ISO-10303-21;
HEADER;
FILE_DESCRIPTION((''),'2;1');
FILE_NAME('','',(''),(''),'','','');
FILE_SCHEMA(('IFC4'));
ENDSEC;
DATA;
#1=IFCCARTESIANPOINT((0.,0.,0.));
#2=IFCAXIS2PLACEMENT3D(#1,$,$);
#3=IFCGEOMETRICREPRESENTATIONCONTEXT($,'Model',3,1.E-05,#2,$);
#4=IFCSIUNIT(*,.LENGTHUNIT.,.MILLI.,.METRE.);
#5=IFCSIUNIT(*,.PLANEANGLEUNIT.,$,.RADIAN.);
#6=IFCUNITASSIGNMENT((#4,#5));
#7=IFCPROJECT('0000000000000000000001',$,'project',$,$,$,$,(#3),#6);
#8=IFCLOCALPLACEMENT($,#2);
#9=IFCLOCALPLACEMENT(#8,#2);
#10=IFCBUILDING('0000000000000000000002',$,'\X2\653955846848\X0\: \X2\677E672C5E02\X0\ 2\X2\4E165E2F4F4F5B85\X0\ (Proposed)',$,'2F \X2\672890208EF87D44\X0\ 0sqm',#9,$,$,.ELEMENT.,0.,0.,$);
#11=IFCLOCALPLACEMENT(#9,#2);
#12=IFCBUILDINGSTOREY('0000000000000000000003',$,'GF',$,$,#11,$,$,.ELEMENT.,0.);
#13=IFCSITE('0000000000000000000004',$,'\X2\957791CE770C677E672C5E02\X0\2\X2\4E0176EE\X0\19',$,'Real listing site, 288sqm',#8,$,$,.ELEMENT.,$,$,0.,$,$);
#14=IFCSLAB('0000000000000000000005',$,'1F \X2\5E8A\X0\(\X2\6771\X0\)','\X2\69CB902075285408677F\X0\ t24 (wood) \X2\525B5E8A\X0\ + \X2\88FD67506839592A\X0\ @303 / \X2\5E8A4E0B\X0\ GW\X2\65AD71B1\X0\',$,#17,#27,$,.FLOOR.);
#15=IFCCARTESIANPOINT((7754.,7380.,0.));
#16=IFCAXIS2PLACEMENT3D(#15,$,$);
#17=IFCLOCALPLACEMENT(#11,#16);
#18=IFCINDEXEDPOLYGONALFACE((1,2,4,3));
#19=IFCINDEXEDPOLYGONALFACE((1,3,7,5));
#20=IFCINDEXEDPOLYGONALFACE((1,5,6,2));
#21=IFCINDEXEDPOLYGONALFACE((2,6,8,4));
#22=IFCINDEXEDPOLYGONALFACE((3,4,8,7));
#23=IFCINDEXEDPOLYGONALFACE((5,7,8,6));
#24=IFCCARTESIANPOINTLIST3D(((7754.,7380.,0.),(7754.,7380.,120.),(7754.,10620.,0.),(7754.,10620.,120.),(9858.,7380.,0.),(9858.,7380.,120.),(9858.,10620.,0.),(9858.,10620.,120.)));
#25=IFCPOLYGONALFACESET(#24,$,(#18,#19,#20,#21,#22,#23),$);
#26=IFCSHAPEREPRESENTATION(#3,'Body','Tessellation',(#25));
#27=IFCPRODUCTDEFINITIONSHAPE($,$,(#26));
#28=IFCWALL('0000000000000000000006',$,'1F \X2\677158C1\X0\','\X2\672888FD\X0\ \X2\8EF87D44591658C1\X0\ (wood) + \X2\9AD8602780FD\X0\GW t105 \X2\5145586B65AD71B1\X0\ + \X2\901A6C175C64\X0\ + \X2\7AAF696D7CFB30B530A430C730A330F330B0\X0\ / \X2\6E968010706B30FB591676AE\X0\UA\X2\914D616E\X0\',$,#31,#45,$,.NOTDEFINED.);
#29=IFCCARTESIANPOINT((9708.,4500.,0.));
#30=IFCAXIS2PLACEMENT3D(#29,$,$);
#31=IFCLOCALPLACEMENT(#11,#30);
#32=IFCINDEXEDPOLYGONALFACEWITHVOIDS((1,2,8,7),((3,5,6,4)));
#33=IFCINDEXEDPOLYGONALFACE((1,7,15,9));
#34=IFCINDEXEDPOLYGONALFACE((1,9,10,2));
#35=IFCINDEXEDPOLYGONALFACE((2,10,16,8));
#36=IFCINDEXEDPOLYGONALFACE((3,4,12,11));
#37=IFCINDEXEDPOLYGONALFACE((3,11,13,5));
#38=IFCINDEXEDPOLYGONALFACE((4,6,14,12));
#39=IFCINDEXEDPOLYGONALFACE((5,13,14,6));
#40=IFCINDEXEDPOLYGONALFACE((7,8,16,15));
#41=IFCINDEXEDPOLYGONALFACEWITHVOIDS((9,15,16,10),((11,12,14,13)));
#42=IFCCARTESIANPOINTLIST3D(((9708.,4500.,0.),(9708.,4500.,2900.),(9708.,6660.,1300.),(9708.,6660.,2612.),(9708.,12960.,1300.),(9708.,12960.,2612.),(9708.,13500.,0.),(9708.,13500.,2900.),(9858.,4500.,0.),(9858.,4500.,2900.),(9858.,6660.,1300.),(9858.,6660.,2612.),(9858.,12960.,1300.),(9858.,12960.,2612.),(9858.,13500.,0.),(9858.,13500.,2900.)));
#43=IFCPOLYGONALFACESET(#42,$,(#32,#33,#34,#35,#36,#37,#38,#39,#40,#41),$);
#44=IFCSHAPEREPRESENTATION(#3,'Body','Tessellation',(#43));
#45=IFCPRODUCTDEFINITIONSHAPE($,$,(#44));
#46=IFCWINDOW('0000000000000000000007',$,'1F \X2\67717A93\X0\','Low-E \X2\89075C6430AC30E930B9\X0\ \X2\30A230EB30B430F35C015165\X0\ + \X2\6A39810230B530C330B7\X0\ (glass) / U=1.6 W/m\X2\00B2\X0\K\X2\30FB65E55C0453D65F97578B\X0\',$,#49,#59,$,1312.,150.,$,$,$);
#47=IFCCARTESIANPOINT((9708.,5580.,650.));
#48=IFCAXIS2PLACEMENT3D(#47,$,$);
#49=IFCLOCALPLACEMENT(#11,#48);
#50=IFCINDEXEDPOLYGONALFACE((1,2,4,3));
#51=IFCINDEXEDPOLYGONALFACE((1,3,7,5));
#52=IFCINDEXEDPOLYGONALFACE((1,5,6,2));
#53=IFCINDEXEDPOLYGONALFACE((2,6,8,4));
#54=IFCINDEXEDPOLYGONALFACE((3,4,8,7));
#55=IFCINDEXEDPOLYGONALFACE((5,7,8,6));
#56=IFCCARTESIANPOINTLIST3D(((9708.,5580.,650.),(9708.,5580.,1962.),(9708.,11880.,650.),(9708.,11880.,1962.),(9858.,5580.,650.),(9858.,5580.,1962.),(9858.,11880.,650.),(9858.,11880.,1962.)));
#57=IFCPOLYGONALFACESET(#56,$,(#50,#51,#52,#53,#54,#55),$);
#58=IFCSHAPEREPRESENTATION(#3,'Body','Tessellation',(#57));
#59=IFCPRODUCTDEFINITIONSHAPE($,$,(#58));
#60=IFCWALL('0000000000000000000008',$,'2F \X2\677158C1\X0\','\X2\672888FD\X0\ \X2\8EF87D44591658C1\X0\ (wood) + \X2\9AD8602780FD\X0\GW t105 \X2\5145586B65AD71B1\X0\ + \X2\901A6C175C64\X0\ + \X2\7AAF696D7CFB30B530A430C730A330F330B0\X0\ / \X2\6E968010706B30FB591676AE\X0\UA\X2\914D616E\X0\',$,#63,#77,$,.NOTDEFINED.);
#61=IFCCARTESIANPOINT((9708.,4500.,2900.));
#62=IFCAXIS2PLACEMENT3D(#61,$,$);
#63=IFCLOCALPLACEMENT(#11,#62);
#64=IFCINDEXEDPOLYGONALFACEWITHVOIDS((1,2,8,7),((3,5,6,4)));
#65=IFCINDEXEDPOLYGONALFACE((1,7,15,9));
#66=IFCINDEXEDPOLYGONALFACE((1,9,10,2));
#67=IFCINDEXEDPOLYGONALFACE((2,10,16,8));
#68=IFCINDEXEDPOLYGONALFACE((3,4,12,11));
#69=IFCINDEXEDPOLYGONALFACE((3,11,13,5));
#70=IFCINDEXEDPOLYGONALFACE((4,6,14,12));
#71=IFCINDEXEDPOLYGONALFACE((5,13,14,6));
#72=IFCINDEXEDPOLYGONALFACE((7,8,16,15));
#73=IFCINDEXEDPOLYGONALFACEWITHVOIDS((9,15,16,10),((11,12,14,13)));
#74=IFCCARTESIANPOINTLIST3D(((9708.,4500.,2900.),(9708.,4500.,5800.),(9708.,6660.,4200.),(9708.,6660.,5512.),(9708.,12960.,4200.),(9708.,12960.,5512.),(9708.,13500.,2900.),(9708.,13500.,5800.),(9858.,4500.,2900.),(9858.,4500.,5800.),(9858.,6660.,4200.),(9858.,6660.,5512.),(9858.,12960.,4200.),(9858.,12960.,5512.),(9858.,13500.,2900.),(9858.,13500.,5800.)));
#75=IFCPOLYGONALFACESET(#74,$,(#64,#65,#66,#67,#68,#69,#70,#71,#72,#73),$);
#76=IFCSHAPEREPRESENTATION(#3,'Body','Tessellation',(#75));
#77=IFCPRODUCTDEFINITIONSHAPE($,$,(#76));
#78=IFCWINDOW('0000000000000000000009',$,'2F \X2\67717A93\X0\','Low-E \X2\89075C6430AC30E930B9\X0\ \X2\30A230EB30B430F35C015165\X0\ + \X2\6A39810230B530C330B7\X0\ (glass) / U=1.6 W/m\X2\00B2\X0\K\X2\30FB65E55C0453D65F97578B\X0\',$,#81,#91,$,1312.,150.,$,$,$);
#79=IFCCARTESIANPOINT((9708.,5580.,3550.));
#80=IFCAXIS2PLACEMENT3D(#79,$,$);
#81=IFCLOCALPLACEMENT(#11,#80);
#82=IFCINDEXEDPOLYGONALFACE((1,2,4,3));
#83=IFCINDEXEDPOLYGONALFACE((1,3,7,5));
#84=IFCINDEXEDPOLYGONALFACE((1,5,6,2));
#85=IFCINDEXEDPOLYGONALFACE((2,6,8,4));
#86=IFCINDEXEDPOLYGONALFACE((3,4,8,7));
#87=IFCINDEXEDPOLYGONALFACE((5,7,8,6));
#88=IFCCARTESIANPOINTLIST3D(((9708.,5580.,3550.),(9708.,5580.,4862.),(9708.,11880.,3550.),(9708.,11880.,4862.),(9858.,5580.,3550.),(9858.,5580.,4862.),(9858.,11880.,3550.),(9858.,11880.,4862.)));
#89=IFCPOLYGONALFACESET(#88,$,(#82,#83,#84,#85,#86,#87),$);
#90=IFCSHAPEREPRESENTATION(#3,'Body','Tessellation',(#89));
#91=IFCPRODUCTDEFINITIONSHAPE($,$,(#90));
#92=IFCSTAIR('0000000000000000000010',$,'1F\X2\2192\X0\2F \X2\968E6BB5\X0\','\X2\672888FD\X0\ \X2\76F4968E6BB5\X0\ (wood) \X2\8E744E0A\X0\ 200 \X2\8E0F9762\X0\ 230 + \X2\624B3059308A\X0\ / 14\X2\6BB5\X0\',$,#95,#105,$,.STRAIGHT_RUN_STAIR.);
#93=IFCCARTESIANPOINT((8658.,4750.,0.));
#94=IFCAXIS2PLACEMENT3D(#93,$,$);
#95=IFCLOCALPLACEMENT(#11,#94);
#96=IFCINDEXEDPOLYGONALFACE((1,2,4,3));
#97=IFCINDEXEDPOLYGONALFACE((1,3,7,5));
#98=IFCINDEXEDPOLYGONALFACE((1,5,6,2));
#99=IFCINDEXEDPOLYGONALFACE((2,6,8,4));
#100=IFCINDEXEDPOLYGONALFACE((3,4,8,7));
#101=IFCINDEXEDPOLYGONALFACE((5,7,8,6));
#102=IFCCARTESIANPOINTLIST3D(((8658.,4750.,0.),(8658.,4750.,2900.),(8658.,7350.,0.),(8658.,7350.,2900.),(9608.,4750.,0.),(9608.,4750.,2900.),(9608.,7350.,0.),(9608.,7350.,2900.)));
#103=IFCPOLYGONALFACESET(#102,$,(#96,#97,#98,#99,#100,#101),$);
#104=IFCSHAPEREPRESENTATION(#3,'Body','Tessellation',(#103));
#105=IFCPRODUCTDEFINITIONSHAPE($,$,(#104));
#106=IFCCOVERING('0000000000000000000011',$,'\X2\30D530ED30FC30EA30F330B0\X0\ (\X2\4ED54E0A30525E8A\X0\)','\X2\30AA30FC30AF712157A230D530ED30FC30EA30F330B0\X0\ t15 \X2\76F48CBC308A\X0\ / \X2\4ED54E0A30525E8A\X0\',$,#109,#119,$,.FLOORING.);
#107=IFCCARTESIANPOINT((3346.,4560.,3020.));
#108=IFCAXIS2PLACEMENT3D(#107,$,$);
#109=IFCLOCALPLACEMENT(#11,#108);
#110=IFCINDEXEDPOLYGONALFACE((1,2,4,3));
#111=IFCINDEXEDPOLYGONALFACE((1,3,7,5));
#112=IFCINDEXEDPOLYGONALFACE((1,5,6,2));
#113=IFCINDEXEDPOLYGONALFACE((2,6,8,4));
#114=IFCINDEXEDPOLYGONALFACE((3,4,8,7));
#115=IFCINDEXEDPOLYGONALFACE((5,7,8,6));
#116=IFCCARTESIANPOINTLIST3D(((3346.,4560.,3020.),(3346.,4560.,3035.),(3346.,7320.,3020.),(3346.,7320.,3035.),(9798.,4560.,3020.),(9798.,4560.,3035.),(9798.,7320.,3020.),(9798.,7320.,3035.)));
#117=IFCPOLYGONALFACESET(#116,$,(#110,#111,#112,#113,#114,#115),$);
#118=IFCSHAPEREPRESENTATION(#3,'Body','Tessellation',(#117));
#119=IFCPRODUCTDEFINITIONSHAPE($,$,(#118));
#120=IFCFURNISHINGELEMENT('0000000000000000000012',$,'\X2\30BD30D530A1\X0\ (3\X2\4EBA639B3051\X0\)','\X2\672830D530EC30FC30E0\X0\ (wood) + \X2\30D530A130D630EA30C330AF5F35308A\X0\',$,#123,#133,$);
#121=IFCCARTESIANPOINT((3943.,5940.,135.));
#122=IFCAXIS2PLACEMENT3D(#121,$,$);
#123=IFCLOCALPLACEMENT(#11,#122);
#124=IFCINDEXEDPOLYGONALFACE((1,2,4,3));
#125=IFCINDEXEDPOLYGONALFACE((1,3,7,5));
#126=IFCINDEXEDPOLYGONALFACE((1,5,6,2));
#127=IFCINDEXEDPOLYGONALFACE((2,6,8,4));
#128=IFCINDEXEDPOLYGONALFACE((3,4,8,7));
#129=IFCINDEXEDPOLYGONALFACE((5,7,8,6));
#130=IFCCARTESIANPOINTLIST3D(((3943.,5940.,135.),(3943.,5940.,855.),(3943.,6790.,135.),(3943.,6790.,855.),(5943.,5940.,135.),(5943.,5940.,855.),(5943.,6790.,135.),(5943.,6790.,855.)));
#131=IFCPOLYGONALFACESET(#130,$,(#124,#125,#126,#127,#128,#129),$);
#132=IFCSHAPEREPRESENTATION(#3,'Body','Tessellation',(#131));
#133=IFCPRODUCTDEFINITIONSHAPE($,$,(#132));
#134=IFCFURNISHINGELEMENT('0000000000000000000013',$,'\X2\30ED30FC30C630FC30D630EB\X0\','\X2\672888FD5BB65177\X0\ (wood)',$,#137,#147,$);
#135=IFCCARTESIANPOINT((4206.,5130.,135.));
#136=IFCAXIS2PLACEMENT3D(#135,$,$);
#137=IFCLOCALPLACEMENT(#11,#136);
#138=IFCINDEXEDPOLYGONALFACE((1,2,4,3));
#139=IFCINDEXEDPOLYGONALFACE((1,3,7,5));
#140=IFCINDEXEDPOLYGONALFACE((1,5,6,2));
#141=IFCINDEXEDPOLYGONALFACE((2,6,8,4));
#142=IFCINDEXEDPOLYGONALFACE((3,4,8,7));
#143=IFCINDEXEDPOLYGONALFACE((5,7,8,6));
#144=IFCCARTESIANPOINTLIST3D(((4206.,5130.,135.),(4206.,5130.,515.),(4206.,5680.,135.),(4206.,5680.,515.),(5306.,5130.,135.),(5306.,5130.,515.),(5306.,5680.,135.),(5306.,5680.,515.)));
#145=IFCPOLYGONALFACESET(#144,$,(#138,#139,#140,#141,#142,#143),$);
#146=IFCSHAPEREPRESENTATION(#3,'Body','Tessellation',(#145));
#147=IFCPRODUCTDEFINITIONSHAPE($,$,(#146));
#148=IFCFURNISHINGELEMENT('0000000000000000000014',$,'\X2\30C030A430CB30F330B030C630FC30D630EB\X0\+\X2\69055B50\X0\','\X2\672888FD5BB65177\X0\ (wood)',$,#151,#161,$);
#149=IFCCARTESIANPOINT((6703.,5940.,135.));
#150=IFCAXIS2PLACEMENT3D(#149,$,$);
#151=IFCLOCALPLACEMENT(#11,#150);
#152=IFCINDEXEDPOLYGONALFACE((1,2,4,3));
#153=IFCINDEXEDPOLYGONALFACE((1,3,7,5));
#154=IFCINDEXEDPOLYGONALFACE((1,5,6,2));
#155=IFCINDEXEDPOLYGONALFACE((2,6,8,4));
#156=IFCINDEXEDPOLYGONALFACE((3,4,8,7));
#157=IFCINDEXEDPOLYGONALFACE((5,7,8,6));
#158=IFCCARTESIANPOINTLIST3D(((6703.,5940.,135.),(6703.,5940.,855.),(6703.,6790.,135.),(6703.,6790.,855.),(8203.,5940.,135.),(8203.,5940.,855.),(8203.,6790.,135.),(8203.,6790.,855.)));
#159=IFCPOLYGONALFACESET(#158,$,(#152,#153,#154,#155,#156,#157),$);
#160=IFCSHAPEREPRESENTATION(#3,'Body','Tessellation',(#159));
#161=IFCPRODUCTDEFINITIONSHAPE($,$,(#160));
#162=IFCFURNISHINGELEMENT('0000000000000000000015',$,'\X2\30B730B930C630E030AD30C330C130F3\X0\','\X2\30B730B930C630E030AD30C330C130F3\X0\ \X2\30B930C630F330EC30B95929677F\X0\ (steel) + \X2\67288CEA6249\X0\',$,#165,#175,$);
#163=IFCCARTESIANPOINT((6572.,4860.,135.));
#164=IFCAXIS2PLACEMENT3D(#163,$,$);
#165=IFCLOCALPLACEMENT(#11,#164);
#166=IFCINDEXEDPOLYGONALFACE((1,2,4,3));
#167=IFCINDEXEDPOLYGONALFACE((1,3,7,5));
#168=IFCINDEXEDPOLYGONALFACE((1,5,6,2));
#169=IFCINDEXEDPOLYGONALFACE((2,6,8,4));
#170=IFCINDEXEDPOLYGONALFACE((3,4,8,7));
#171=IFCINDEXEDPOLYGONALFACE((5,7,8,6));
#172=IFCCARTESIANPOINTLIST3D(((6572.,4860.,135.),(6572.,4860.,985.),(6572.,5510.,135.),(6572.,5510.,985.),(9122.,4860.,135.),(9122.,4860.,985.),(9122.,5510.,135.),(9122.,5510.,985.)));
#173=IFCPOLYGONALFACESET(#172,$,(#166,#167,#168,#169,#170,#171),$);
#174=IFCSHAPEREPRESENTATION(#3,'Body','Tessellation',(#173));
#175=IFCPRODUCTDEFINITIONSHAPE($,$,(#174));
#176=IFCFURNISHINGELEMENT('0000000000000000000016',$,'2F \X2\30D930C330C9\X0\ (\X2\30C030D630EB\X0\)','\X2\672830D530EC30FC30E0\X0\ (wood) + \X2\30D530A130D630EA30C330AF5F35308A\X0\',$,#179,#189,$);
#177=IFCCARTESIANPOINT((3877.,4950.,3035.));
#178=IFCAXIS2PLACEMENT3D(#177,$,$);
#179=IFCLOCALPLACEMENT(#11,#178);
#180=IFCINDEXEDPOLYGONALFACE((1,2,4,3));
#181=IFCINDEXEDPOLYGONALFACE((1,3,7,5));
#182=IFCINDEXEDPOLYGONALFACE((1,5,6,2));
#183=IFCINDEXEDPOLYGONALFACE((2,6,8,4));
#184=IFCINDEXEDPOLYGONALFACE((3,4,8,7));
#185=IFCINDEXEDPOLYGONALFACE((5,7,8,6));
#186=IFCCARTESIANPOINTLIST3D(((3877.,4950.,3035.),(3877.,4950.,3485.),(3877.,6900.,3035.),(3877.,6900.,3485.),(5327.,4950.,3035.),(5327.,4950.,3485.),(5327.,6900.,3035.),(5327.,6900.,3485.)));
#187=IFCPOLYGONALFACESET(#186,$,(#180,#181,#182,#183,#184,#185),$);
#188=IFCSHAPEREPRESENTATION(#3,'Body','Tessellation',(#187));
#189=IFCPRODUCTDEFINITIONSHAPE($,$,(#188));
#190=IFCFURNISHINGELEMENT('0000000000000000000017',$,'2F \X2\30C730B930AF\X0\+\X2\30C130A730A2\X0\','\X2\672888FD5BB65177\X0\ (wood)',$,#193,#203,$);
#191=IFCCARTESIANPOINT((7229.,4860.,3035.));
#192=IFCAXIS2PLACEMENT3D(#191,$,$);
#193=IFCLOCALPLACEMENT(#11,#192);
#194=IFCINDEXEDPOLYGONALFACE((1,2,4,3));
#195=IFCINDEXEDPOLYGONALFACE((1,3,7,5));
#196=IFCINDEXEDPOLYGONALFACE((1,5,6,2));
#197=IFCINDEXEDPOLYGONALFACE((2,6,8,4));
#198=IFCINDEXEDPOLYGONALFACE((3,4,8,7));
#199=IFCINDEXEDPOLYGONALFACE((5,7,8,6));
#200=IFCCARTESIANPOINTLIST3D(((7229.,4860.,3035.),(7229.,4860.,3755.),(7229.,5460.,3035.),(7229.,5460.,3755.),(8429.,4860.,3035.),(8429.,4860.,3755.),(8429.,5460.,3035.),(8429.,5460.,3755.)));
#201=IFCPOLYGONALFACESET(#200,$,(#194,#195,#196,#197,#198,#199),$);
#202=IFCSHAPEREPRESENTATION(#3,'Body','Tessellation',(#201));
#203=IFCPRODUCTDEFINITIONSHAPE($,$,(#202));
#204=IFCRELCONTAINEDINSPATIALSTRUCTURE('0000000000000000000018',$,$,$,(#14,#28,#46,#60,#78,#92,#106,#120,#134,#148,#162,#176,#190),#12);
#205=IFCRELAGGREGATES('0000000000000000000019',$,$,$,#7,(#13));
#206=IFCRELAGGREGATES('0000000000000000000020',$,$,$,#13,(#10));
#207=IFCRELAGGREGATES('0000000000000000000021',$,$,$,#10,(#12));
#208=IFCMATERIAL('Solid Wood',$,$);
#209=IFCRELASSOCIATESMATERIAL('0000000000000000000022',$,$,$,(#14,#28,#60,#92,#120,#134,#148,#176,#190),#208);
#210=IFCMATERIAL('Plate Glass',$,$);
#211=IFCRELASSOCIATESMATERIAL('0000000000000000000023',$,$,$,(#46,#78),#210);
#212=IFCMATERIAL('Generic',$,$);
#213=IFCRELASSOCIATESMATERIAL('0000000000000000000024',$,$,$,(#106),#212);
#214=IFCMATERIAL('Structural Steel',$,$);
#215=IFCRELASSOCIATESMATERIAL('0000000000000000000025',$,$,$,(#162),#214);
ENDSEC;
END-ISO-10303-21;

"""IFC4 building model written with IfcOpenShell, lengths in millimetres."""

from ifc_helpers import new_model, si_unit, frame, frame_2d, origin, place, context, project, spatial, rectangle, extrude, material, element, fill, save


model = new_model("IFC4")

# Units and contexts
model_context = context("Model", 3, precision=1e-05, world=origin())
ifc_project = project(units=[si_unit("LENGTHUNIT", "METRE", prefix="MILLI"), si_unit("PLANEANGLEUNIT", "RADIAN")], contexts=[model_context])

# Site, building, storey
site_placement = place(None, origin())
site = spatial("IfcSite", under=ifc_project, at=site_placement, Name="長野県松本市2丁目19", ObjectType="Real listing site, 288sqm", CompositionType="ELEMENT", RefElevation=0.0)
building_placement = place(site_placement, origin())
building = spatial("IfcBuilding", under=site, at=building_placement, Name="改善案: 松本市 2世帯住宅 (Proposed)", ObjectType="2F 木造軸組 0sqm", CompositionType="ELEMENT", ElevationOfRefHeight=0.0, ElevationOfTerrain=0.0)
storey_placement = place(building_placement, origin())
storey = spatial("IfcBuildingStorey", under=building, at=storey_placement, Name="GF", CompositionType="ELEMENT", Elevation=0.0)

# Slab
ifc_material_1 = material(Name="Solid Wood")
slab_placement = place(storey_placement, frame((7754.0, 7380.0, 0.0)))
element("IfcSlab", 1, at=slab_placement, inside=storey, material=ifc_material_1, Name="1F 床(東)", Description="構造用合板 t24 (wood) 剛床 + 製材根太 @303 / 床下 GW断熱", PredefinedType="FLOOR", context=model_context, shape_type="SweptSolid", body=[
    extrude(rectangle(XDim=2104.0, YDim=3240.0, at=frame_2d((1052.0, 1620.0))), frame((7754.0, 7380.0, 0.0)), (0.0, 0.0, 1.0), 120.0),
])

# Wall, opening, window
wall_1_placement = place(storey_placement, frame((9708.0, 4500.0, 0.0)))
wall_1 = element("IfcWall", 2, at=wall_1_placement, inside=storey, material=ifc_material_1, Name="1F 東壁", Description="木製 軸組外壁 (wood) + 高性能GW t105 充填断熱 + 通気層 + 窯業系サイディング / 準耐火・外皮UA配慮", PredefinedType="NOTDEFINED", context=model_context, shape_type="SweptSolid", body=[
    extrude(rectangle(XDim=150.0, YDim=9000.0, at=frame_2d((75.0, 4500.0))), frame((9708.0, 4500.0, 0.0)), (0.0, 0.0, 1.0), 2900.0),
])
opening_1_placement = place(storey_placement, frame((9708.0, 5580.0, 650.0)))
opening_1 = element("IfcOpeningElement", 3, at=opening_1_placement, cuts=wall_1, PredefinedType="NOTDEFINED", context=model_context, shape_type="SweptSolid", body=[
    extrude(rectangle(XDim=150.0, YDim=6300.0, at=frame_2d((75.0, 3150.0))), frame((9708.0, 5580.0, 650.0)), (0.0, 0.0, 1.0), 1312.0),
])
ifc_material_2 = material(Name="Plate Glass")
window_1_placement = place(storey_placement, frame((9708.0, 5580.0, 650.0)))
window_1 = element("IfcWindow", 4, at=window_1_placement, inside=storey, material=ifc_material_2, Name="1F 東窓", Description="Low-E 複層ガラス アルゴン封入 + 樹脂サッシ (glass) / U=1.6 W/m²K・日射取得型", OverallHeight=1312.0, OverallWidth=150.0, context=model_context, shape_type="SweptSolid", body=[
    extrude(rectangle(XDim=150.0, YDim=6300.0, at=frame_2d((75.0, 3150.0))), frame((9708.0, 5580.0, 650.0)), (0.0, 0.0, 1.0), 1312.0),
])
fill(opening_1, window_1)

# Wall, opening, window
wall_2_placement = place(storey_placement, frame((9708.0, 4500.0, 2900.0)))
wall_2 = element("IfcWall", 5, at=wall_2_placement, inside=storey, material=ifc_material_1, Name="2F 東壁", Description="木製 軸組外壁 (wood) + 高性能GW t105 充填断熱 + 通気層 + 窯業系サイディング / 準耐火・外皮UA配慮", PredefinedType="NOTDEFINED", context=model_context, shape_type="SweptSolid", body=[
    extrude(rectangle(XDim=150.0, YDim=9000.0, at=frame_2d((75.0, 4500.0))), frame((9708.0, 4500.0, 2900.0)), (0.0, 0.0, 1.0), 2900.0),
])
opening_2_placement = place(storey_placement, frame((9708.0, 5580.0, 3550.0)))
opening_2 = element("IfcOpeningElement", 6, at=opening_2_placement, cuts=wall_2, PredefinedType="NOTDEFINED", context=model_context, shape_type="SweptSolid", body=[
    extrude(rectangle(XDim=150.0, YDim=6300.0, at=frame_2d((75.0, 3150.0))), frame((9708.0, 5580.0, 3550.0)), (0.0, 0.0, 1.0), 1312.0),
])
window_2_placement = place(storey_placement, frame((9708.0, 5580.0, 3550.0)))
window_2 = element("IfcWindow", 7, at=window_2_placement, inside=storey, material=ifc_material_2, Name="2F 東窓", Description="Low-E 複層ガラス アルゴン封入 + 樹脂サッシ (glass) / U=1.6 W/m²K・日射取得型", OverallHeight=1312.0, OverallWidth=150.0, context=model_context, shape_type="SweptSolid", body=[
    extrude(rectangle(XDim=150.0, YDim=6300.0, at=frame_2d((75.0, 3150.0))), frame((9708.0, 5580.0, 3550.0)), (0.0, 0.0, 1.0), 1312.0),
])
fill(opening_2, window_2)

# Stair
stair_placement = place(storey_placement, frame((8658.0, 4750.0, 0.0)))
element("IfcStair", 8, at=stair_placement, inside=storey, material=ifc_material_1, Name="1F→2F 階段", Description="木製 直階段 (wood) 蹴上 200 踏面 230 + 手すり / 14段", PredefinedType="STRAIGHT_RUN_STAIR", context=model_context, shape_type="SweptSolid", body=[
    extrude(rectangle(XDim=950.0, YDim=2600.0, at=frame_2d((475.0, 1300.0))), frame((8658.0, 4750.0, 0.0)), (0.0, 0.0, 1.0), 2900.0),
])

# Covering
ifc_material_3 = material(Name="Generic")
covering_placement = place(storey_placement, frame((3346.0, 4560.0, 3020.0)))
element("IfcCovering", 9, at=covering_placement, inside=storey, material=ifc_material_3, Name="フローリング (仕上げ床)", Description="オーク無垢フローリング t15 直貼り / 仕上げ床", PredefinedType="FLOORING", context=model_context, shape_type="SweptSolid", body=[
    extrude(rectangle(XDim=6452.0, YDim=2760.0, at=frame_2d((3226.0, 1380.0))), frame((3346.0, 4560.0, 3020.0)), (0.0, 0.0, 1.0), 15.0),
])

# Furnishing elements
furnishing_1_placement = place(storey_placement, frame((3943.0, 5940.0, 135.0)))
element("IfcFurnishingElement", 10, at=furnishing_1_placement, inside=storey, material=ifc_material_1, Name="ソファ (3人掛け)", Description="木フレーム (wood) + ファブリック張り", context=model_context, shape_type="SweptSolid", body=[
    extrude(rectangle(XDim=2000.0, YDim=850.0, at=frame_2d((1000.0, 425.0))), frame((3943.0, 5940.0, 135.0)), (0.0, 0.0, 1.0), 720.0),
])
furnishing_2_placement = place(storey_placement, frame((4206.0, 5130.0, 135.0)))
element("IfcFurnishingElement", 11, at=furnishing_2_placement, inside=storey, material=ifc_material_1, Name="ローテーブル", Description="木製家具 (wood)", context=model_context, shape_type="SweptSolid", body=[
    extrude(rectangle(XDim=1100.0, YDim=550.0, at=frame_2d((550.0, 275.0))), frame((4206.0, 5130.0, 135.0)), (0.0, 0.0, 1.0), 380.0),
])
furnishing_3_placement = place(storey_placement, frame((6703.0, 5940.0, 135.0)))
element("IfcFurnishingElement", 12, at=furnishing_3_placement, inside=storey, material=ifc_material_1, Name="ダイニングテーブル+椅子", Description="木製家具 (wood)", context=model_context, shape_type="SweptSolid", body=[
    extrude(rectangle(XDim=1500.0, YDim=850.0, at=frame_2d((750.0, 425.0))), frame((6703.0, 5940.0, 135.0)), (0.0, 0.0, 1.0), 720.0),
])
ifc_material_4 = material(Name="Structural Steel")
furnishing_4_placement = place(storey_placement, frame((6572.0, 4860.0, 135.0)))
element("IfcFurnishingElement", 13, at=furnishing_4_placement, inside=storey, material=ifc_material_4, Name="システムキッチン", Description="システムキッチン ステンレス天板 (steel) + 木質扉", context=model_context, shape_type="SweptSolid", body=[
    extrude(rectangle(XDim=2550.0, YDim=650.0, at=frame_2d((1275.0, 325.0))), frame((6572.0, 4860.0, 135.0)), (0.0, 0.0, 1.0), 850.0),
])
furnishing_5_placement = place(storey_placement, frame((3877.0, 4950.0, 3035.0)))
element("IfcFurnishingElement", 14, at=furnishing_5_placement, inside=storey, material=ifc_material_1, Name="2F ベッド (ダブル)", Description="木フレーム (wood) + ファブリック張り", context=model_context, shape_type="SweptSolid", body=[
    extrude(rectangle(XDim=1450.0, YDim=1950.0, at=frame_2d((725.0, 975.0))), frame((3877.0, 4950.0, 3035.0)), (0.0, 0.0, 1.0), 450.0),
])
furnishing_6_placement = place(storey_placement, frame((7229.0, 4860.0, 3035.0)))
element("IfcFurnishingElement", 15, at=furnishing_6_placement, inside=storey, material=ifc_material_1, Name="2F デスク+チェア", Description="木製家具 (wood)", context=model_context, shape_type="SweptSolid", body=[
    extrude(rectangle(XDim=1200.0, YDim=600.0, at=frame_2d((600.0, 300.0))), frame((7229.0, 4860.0, 3035.0)), (0.0, 0.0, 1.0), 720.0),
])

save(model, "model.ifc")
